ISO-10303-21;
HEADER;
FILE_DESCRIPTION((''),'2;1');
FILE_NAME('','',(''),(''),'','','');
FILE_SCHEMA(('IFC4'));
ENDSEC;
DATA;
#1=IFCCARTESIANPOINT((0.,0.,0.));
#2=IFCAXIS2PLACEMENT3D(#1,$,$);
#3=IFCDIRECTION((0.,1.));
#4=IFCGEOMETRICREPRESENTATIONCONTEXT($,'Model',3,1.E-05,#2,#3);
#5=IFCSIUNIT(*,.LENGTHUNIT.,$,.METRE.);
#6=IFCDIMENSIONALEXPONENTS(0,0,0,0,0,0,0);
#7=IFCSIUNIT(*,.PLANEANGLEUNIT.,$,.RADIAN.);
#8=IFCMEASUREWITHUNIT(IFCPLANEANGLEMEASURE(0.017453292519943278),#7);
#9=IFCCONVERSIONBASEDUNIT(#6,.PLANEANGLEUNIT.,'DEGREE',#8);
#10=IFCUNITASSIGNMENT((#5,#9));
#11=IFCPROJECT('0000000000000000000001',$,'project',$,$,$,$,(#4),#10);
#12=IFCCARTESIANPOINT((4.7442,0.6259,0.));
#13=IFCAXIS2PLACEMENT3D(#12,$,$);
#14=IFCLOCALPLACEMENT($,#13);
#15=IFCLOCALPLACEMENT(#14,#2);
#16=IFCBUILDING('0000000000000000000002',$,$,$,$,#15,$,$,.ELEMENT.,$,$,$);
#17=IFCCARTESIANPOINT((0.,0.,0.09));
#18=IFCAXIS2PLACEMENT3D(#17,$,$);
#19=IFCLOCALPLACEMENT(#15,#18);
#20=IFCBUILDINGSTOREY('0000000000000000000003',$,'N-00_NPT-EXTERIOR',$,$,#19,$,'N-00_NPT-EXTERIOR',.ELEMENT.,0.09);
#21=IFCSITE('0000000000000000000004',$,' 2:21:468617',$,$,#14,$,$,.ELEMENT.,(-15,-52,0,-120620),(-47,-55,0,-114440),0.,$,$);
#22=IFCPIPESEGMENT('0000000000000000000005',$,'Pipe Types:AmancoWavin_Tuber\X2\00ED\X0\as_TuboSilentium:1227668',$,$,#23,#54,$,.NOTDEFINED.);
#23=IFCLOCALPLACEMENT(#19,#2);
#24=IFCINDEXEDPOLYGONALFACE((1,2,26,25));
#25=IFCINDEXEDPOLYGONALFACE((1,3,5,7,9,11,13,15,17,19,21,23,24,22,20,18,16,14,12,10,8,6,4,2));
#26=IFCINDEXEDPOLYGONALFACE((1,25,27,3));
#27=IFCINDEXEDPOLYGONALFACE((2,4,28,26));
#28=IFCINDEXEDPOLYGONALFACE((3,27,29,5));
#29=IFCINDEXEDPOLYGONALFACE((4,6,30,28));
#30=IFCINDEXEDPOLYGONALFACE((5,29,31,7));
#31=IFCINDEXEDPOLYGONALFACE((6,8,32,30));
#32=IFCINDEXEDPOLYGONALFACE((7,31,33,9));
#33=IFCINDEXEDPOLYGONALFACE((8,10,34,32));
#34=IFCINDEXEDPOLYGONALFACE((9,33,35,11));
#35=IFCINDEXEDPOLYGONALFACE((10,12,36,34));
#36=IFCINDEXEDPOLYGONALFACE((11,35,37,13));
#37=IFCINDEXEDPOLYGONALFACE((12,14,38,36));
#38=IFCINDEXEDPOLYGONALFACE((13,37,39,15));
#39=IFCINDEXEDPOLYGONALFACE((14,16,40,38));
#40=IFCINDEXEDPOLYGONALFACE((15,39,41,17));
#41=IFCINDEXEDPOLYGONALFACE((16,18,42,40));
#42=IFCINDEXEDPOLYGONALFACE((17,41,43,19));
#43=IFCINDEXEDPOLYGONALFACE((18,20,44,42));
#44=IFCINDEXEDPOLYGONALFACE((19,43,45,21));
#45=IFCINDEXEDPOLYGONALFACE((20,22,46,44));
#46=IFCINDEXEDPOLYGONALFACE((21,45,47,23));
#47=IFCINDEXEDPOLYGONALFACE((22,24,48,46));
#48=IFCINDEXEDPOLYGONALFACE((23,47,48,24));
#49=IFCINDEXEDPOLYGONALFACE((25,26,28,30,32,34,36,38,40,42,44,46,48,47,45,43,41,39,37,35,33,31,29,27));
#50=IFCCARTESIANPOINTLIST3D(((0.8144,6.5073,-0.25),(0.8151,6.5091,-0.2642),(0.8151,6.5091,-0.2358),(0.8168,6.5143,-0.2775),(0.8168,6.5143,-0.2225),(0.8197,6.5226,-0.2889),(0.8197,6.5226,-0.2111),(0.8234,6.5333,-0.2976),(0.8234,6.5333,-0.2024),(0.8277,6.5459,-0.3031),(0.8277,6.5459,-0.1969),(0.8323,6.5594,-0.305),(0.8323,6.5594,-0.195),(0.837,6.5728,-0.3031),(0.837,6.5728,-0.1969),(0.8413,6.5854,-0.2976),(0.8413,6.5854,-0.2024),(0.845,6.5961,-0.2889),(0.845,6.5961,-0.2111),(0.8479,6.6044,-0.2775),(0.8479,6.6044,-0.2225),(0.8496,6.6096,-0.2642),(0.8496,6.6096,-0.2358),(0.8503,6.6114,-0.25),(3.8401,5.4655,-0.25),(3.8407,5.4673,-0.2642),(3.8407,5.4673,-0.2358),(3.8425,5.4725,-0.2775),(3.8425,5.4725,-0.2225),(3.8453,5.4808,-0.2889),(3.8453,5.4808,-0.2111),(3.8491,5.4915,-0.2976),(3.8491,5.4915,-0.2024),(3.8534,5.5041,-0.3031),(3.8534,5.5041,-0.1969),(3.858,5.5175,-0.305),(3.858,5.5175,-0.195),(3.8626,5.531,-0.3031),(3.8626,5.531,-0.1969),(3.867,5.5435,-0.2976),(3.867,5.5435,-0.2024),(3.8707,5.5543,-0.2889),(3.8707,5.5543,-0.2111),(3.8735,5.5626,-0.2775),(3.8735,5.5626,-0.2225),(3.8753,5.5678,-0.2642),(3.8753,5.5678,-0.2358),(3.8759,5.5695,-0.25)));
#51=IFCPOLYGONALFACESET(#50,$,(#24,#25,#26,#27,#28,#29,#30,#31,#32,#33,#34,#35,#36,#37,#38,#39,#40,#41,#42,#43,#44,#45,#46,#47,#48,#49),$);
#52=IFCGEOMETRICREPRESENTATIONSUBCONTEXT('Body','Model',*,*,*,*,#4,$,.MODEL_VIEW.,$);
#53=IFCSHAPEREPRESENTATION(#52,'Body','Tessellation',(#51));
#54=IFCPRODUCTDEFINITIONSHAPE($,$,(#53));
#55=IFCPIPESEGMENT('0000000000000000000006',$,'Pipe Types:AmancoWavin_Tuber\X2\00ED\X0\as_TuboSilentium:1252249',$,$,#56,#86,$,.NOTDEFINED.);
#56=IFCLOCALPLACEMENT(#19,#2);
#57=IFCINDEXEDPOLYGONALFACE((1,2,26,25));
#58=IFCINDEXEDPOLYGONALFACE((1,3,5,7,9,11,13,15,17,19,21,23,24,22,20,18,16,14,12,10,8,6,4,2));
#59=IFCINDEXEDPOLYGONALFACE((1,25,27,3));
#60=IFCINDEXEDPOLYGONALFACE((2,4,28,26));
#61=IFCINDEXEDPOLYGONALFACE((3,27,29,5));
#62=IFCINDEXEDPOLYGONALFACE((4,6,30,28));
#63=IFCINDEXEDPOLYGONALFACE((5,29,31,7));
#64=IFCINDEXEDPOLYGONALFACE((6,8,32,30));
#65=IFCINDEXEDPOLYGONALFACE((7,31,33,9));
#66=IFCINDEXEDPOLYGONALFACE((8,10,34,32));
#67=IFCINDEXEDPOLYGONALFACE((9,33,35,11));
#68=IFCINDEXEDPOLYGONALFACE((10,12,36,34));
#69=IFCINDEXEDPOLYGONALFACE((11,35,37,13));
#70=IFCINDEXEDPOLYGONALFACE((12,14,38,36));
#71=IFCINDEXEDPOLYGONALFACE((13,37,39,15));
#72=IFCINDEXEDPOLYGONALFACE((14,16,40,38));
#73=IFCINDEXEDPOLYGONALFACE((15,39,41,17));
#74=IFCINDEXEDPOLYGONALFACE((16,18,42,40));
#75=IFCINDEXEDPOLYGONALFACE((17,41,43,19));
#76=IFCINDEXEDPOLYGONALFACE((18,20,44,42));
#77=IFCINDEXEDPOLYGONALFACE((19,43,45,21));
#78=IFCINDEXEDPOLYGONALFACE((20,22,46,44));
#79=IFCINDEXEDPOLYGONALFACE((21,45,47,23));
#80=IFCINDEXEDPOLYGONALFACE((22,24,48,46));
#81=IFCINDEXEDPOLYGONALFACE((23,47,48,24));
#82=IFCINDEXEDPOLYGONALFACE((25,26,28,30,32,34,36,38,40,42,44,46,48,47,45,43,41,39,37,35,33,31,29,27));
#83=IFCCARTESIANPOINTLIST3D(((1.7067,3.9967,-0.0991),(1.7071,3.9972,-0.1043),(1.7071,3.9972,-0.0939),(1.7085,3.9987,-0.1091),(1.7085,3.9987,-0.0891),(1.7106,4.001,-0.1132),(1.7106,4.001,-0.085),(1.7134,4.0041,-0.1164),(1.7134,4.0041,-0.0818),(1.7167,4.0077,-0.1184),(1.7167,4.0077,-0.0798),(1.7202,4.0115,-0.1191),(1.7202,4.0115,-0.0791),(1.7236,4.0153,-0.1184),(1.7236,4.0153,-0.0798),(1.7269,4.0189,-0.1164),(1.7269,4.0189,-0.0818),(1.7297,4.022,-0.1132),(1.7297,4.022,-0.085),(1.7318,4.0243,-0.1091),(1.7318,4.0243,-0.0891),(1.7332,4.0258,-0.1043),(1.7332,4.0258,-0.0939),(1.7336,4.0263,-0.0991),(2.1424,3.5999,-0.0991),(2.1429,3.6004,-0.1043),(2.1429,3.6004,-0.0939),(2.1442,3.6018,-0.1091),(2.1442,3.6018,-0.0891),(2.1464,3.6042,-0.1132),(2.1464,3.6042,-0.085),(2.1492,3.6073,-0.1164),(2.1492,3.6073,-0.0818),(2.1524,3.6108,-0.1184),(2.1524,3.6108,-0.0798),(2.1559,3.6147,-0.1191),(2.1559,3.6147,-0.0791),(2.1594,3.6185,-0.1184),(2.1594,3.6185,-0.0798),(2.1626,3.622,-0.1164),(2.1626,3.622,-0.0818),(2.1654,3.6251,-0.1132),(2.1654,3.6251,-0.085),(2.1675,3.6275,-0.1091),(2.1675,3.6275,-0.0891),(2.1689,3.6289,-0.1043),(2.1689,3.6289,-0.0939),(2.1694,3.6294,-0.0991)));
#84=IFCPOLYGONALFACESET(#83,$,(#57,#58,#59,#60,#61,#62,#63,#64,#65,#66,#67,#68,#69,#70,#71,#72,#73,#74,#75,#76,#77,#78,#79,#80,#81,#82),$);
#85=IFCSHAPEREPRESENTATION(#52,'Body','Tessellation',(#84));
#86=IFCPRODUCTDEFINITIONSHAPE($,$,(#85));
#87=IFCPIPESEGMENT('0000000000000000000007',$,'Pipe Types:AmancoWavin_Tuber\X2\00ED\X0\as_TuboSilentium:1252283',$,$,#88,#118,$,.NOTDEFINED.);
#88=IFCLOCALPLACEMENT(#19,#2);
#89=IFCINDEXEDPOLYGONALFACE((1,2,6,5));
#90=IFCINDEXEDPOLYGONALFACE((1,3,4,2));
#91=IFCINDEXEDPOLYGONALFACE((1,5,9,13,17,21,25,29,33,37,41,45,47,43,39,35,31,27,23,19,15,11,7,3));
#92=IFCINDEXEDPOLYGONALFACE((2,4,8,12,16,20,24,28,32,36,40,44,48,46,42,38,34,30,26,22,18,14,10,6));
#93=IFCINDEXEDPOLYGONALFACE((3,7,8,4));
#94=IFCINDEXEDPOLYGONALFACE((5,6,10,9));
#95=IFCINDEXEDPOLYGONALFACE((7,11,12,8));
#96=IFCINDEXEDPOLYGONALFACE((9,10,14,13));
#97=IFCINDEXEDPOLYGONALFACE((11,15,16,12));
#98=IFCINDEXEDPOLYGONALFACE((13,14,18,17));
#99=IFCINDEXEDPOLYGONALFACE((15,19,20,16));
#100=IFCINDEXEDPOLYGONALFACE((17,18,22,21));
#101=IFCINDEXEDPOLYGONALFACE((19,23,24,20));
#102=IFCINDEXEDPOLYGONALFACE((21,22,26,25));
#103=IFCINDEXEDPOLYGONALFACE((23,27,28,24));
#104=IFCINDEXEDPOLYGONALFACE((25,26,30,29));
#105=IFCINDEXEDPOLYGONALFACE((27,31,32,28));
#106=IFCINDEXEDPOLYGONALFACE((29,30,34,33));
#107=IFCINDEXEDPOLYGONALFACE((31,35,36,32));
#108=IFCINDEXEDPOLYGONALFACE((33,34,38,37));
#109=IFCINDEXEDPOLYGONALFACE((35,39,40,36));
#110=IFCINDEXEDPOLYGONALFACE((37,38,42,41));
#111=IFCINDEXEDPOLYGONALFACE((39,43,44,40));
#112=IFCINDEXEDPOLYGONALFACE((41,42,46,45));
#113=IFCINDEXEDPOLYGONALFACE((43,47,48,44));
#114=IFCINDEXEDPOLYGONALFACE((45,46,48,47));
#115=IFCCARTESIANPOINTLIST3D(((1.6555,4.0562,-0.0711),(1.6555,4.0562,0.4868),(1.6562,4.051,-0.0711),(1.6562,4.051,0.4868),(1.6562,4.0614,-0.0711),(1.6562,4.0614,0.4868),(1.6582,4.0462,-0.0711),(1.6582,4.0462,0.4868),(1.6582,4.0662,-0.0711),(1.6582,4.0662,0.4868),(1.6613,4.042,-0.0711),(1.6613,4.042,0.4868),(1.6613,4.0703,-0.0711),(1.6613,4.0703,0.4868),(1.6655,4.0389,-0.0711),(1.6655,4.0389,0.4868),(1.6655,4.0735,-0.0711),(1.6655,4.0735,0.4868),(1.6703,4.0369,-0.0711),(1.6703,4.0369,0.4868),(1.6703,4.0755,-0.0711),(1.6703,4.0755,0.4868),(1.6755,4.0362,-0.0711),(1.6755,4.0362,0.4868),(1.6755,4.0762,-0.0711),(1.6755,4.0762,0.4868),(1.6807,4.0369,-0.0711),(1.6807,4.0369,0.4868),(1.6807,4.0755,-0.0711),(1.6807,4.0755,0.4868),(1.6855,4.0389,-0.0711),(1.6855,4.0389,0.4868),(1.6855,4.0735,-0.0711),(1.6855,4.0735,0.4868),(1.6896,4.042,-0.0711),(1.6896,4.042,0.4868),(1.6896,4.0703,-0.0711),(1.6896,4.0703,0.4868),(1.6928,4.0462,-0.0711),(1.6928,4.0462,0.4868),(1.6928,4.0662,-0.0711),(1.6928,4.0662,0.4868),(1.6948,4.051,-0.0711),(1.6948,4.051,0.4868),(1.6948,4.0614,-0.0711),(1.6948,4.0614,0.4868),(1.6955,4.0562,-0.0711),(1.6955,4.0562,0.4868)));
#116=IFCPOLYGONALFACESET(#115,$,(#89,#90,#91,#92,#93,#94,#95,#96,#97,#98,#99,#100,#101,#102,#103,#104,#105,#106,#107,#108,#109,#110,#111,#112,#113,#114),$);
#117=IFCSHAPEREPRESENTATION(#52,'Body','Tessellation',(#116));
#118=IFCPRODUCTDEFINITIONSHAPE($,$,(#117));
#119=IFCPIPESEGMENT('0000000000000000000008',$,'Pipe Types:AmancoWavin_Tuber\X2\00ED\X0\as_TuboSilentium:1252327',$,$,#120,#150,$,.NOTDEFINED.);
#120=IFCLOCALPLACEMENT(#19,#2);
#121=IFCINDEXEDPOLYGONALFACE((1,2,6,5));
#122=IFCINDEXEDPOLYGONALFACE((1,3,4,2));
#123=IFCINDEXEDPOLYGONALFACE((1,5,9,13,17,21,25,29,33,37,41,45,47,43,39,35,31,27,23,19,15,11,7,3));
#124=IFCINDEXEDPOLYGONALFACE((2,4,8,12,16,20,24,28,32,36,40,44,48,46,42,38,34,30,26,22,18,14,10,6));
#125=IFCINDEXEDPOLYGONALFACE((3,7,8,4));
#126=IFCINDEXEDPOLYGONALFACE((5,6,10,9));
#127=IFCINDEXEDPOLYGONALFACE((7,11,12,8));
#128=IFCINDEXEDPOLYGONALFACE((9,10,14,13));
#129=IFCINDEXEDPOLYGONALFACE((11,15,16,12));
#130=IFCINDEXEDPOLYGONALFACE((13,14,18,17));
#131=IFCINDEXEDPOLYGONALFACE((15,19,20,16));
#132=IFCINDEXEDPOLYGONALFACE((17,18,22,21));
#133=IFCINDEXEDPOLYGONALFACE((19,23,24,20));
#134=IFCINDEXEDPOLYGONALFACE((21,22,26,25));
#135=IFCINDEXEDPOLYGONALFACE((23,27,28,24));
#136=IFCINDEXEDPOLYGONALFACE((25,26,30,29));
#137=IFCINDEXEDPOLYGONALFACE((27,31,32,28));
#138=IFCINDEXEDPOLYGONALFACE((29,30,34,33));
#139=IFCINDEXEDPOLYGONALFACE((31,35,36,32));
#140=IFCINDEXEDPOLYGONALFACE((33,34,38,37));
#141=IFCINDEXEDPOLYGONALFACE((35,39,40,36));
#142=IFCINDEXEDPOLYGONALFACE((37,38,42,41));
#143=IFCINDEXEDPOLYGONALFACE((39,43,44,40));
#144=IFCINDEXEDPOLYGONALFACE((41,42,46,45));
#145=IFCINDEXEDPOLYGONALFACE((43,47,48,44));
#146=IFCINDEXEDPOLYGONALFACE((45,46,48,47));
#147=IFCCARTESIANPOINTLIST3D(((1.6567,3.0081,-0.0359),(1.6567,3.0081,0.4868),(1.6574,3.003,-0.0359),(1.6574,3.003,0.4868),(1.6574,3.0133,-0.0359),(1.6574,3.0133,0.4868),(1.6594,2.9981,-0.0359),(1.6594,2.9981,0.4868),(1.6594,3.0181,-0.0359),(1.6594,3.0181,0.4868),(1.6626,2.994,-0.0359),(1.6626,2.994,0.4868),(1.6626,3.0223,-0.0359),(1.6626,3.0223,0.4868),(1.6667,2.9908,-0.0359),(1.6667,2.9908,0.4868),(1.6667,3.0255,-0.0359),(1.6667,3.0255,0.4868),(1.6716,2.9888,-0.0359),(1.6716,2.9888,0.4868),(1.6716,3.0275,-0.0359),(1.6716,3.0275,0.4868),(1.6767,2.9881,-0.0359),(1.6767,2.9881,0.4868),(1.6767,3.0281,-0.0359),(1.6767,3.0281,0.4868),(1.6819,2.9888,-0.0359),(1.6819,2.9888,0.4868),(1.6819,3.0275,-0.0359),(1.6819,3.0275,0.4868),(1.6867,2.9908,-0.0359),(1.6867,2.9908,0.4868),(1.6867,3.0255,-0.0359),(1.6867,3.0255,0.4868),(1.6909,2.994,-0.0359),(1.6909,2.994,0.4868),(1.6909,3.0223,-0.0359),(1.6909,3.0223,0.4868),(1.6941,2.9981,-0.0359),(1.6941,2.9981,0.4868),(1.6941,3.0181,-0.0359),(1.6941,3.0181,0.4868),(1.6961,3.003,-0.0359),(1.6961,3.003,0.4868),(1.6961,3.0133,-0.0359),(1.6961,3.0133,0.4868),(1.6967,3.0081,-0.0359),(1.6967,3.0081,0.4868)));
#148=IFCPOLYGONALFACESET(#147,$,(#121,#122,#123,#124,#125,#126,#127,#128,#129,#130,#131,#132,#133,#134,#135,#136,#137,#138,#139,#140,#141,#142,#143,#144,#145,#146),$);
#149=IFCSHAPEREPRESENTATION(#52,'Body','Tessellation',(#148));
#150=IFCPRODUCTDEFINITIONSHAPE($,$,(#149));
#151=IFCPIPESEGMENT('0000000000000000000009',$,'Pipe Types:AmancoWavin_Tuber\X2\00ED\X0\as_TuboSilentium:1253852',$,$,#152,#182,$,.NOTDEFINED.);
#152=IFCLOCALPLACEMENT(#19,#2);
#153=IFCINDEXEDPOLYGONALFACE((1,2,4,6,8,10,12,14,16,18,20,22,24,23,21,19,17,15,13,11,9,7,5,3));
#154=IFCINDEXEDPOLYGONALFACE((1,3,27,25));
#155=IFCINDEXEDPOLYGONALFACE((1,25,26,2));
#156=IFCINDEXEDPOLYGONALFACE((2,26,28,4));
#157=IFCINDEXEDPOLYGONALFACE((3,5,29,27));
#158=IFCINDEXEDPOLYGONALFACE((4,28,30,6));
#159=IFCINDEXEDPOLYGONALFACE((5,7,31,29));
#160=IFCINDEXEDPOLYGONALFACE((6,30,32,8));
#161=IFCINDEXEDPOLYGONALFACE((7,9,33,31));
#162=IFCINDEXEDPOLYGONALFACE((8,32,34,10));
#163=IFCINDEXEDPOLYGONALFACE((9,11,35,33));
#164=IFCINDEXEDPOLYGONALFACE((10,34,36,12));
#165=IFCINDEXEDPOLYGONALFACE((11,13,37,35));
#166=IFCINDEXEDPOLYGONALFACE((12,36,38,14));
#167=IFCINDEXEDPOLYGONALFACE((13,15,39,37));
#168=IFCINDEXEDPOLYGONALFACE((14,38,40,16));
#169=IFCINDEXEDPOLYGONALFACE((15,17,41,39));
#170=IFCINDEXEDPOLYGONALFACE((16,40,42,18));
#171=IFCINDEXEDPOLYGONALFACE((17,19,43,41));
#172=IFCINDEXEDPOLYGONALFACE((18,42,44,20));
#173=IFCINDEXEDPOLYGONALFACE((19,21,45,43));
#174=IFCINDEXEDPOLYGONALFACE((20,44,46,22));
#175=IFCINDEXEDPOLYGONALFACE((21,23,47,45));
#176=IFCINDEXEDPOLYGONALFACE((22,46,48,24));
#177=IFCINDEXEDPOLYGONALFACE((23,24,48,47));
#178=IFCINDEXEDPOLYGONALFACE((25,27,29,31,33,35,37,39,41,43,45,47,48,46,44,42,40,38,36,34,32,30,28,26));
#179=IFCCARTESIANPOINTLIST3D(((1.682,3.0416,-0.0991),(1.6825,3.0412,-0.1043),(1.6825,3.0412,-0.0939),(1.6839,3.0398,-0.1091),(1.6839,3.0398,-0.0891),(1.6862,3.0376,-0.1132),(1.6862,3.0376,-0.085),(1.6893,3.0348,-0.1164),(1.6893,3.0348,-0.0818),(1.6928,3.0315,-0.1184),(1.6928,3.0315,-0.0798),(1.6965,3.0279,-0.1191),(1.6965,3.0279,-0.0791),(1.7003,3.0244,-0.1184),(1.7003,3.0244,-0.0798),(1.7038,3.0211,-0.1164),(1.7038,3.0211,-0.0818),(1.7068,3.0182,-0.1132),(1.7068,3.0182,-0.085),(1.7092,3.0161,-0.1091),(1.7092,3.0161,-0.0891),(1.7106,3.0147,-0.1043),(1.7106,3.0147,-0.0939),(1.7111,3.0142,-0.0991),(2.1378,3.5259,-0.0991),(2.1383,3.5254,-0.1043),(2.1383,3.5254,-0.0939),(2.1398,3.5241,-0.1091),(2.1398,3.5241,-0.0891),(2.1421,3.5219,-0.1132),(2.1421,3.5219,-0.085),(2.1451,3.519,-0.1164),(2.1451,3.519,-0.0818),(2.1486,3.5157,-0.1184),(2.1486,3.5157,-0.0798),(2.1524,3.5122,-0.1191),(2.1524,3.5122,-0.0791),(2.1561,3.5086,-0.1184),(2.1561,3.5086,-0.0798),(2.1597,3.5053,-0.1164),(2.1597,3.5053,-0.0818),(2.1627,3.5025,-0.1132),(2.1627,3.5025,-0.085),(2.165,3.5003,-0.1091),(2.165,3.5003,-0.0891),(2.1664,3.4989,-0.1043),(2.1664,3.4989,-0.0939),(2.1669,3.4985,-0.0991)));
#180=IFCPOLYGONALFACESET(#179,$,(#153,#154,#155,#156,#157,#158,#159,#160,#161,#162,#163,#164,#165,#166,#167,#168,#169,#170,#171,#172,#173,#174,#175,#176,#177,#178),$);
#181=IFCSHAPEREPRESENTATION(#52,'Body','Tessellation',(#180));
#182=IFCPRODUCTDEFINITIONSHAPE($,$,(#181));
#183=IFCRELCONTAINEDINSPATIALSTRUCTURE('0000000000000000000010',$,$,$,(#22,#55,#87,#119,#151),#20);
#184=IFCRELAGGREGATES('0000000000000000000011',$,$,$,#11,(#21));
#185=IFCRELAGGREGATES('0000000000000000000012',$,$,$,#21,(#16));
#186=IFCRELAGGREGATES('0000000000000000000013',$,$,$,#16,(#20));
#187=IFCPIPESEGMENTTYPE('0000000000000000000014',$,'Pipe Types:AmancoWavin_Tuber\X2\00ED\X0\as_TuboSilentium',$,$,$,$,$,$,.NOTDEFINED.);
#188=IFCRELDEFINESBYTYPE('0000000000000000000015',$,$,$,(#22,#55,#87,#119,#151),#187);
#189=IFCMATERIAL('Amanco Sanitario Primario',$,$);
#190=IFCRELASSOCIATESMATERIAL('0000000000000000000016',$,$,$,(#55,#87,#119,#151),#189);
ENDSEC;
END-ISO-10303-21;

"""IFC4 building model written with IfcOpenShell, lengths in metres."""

from ifc_helpers import new_model, entity, si_unit, converted_unit, direction, frame, origin, place, context, subcontext, project, spatial, arc, indexed_curve, outline, extrude, material, type_object, element, save


model = new_model("IFC4")

# Units and contexts
model_context = context("Model", 3, precision=1e-05, world=origin(), true_north=direction((0.0, 1.0)))
body_context = subcontext(model_context, "Body", "Model", "MODEL_VIEW")
ifc_project = project(units=[si_unit("LENGTHUNIT", "METRE"), converted_unit("PLANEANGLEUNIT", "DEGREE", entity("IfcPlaneAngleMeasure", 0.017453292519943278), si_unit("PLANEANGLEUNIT", "RADIAN"), dimensions=[0, 0, 0, 0, 0, 0, 0])], contexts=[model_context])

# Site, building, storey
site_placement = place(None, frame((4.7442, 0.6259, 0.0)))
site = spatial("IfcSite", under=ifc_project, at=site_placement, Name=" 2:21:468617", CompositionType="ELEMENT", RefLatitude=(-15, -52, 0, -120620), RefLongitude=(-47, -55, 0, -114440), RefElevation=0.0)
building_placement = place(site_placement, origin())
building = spatial("IfcBuilding", under=site, at=building_placement, CompositionType="ELEMENT")
storey_placement = place(building_placement, frame((0.0, 0.0, 0.09)))
storey = spatial("IfcBuildingStorey", under=building, at=storey_placement, Name="N-00_NPT-EXTERIOR", LongName="N-00_NPT-EXTERIOR", CompositionType="ELEMENT", Elevation=0.09)

# Pipe segments
pipe_segment_type_1 = type_object("IfcPipeSegmentType", Name="Pipe Types:AmancoWavin_Tuberías_TuboSilentium", PredefinedType="NOTDEFINED")
pipe_segment_1_placement = place(storey_placement, origin())
element("IfcPipeSegment", 1, at=pipe_segment_1_placement, inside=storey, type_object=pipe_segment_type_1, Name="Pipe Types:AmancoWavin_Tuberías_TuboSilentium:1227668", PredefinedType="NOTDEFINED", context=body_context, shape_type="SweptSolid", body=[
    extrude(outline(indexed_curve([(0.055, 0.0), (0.0389, 0.0389), (0.0, 0.055), (-0.0389, 0.0389), (-0.055, 0.0), (-0.0389, -0.0389), (0.0, -0.055), (0.0389, -0.0389)], segments=[arc(1, 2, 3), arc(3, 4, 5), arc(5, 6, 7), arc(7, 8, 1)], self_intersect=False)), frame((0.8323, 6.5594, -0.25), z_axis=(0.945519, -0.325568, 0.0), x_axis=(-0.325568, -0.945519, 0.0)), (0.0, 0.0, 1.0), 3.2),
])
ifc_material_1 = material(Name="Amanco Sanitario Primario")
pipe_segment_2_placement = place(storey_placement, origin())
element("IfcPipeSegment", 2, at=pipe_segment_2_placement, inside=storey, type_object=pipe_segment_type_1, material=ifc_material_1, Name="Pipe Types:AmancoWavin_Tuberías_TuboSilentium:1252249", PredefinedType="NOTDEFINED", context=body_context, shape_type="SweptSolid", body=[
    extrude(outline(indexed_curve([(0.02, 0.0), (0.0141, 0.0141), (0.0, 0.02), (-0.0141, 0.0141), (-0.02, 0.0), (-0.0141, -0.0141), (0.0, -0.02), (0.0141, -0.0141)], segments=[arc(1, 2, 3), arc(3, 4, 5), arc(5, 6, 7), arc(7, 8, 1)], self_intersect=False)), frame((2.1559, 3.6147, -0.0991), z_axis=(-0.739321, 0.673354, 0.0), x_axis=(0.673354, 0.739321, 0.0)), (0.0, 0.0, 1.0), 0.5894),
])
pipe_segment_3_placement = place(storey_placement, origin())
element("IfcPipeSegment", 3, at=pipe_segment_3_placement, inside=storey, type_object=pipe_segment_type_1, material=ifc_material_1, Name="Pipe Types:AmancoWavin_Tuberías_TuboSilentium:1252283", PredefinedType="NOTDEFINED", context=body_context, shape_type="SweptSolid", body=[
    extrude(outline(indexed_curve([(0.02, 0.0), (0.0141, 0.0141), (0.0, 0.02), (-0.0141, 0.0141), (-0.02, 0.0), (-0.0141, -0.0141), (0.0, -0.02), (0.0141, -0.0141)], segments=[arc(1, 2, 3), arc(3, 4, 5), arc(5, 6, 7), arc(7, 8, 1)], self_intersect=False)), frame((1.6755, 4.0562, -0.0711), z_axis=(0.0, 0.0, 1.0), x_axis=(-1.0, 0.0, 0.0)), (0.0, 0.0, 1.0), 0.5579),
])
pipe_segment_4_placement = place(storey_placement, origin())
element("IfcPipeSegment", 4, at=pipe_segment_4_placement, inside=storey, type_object=pipe_segment_type_1, material=ifc_material_1, Name="Pipe Types:AmancoWavin_Tuberías_TuboSilentium:1252327", PredefinedType="NOTDEFINED", context=body_context, shape_type="SweptSolid", body=[
    extrude(outline(indexed_curve([(0.02, 0.0), (0.0141, 0.0141), (0.0, 0.02), (-0.0141, 0.0141), (-0.02, 0.0), (-0.0141, -0.0141), (0.0, -0.02), (0.0141, -0.0141)], segments=[arc(1, 2, 3), arc(3, 4, 5), arc(5, 6, 7), arc(7, 8, 1)], self_intersect=False)), frame((1.6767, 3.0081, -0.0359), z_axis=(0.0, 0.0, 1.0), x_axis=(-1.0, 0.0, 0.0)), (0.0, 0.0, 1.0), 0.5227),
])
pipe_segment_5_placement = place(storey_placement, origin())
element("IfcPipeSegment", 5, at=pipe_segment_5_placement, inside=storey, type_object=pipe_segment_type_1, material=ifc_material_1, Name="Pipe Types:AmancoWavin_Tuberías_TuboSilentium:1253852", PredefinedType="NOTDEFINED", context=body_context, shape_type="SweptSolid", body=[
    extrude(outline(indexed_curve([(0.02, 0.0), (0.0141, 0.0141), (0.0, 0.02), (-0.0141, 0.0141), (-0.02, 0.0), (-0.0141, -0.0141), (0.0, -0.02), (0.0141, -0.0141)], segments=[arc(1, 2, 3), arc(3, 4, 5), arc(5, 6, 7), arc(7, 8, 1)], self_intersect=False)), frame((1.6965, 3.0279, -0.0991), z_axis=(0.685413, 0.728154, 0.0), x_axis=(0.728154, -0.685413, 0.0)), (0.0, 0.0, 1.0), 0.665),
])

save(model, "model.ifc")
